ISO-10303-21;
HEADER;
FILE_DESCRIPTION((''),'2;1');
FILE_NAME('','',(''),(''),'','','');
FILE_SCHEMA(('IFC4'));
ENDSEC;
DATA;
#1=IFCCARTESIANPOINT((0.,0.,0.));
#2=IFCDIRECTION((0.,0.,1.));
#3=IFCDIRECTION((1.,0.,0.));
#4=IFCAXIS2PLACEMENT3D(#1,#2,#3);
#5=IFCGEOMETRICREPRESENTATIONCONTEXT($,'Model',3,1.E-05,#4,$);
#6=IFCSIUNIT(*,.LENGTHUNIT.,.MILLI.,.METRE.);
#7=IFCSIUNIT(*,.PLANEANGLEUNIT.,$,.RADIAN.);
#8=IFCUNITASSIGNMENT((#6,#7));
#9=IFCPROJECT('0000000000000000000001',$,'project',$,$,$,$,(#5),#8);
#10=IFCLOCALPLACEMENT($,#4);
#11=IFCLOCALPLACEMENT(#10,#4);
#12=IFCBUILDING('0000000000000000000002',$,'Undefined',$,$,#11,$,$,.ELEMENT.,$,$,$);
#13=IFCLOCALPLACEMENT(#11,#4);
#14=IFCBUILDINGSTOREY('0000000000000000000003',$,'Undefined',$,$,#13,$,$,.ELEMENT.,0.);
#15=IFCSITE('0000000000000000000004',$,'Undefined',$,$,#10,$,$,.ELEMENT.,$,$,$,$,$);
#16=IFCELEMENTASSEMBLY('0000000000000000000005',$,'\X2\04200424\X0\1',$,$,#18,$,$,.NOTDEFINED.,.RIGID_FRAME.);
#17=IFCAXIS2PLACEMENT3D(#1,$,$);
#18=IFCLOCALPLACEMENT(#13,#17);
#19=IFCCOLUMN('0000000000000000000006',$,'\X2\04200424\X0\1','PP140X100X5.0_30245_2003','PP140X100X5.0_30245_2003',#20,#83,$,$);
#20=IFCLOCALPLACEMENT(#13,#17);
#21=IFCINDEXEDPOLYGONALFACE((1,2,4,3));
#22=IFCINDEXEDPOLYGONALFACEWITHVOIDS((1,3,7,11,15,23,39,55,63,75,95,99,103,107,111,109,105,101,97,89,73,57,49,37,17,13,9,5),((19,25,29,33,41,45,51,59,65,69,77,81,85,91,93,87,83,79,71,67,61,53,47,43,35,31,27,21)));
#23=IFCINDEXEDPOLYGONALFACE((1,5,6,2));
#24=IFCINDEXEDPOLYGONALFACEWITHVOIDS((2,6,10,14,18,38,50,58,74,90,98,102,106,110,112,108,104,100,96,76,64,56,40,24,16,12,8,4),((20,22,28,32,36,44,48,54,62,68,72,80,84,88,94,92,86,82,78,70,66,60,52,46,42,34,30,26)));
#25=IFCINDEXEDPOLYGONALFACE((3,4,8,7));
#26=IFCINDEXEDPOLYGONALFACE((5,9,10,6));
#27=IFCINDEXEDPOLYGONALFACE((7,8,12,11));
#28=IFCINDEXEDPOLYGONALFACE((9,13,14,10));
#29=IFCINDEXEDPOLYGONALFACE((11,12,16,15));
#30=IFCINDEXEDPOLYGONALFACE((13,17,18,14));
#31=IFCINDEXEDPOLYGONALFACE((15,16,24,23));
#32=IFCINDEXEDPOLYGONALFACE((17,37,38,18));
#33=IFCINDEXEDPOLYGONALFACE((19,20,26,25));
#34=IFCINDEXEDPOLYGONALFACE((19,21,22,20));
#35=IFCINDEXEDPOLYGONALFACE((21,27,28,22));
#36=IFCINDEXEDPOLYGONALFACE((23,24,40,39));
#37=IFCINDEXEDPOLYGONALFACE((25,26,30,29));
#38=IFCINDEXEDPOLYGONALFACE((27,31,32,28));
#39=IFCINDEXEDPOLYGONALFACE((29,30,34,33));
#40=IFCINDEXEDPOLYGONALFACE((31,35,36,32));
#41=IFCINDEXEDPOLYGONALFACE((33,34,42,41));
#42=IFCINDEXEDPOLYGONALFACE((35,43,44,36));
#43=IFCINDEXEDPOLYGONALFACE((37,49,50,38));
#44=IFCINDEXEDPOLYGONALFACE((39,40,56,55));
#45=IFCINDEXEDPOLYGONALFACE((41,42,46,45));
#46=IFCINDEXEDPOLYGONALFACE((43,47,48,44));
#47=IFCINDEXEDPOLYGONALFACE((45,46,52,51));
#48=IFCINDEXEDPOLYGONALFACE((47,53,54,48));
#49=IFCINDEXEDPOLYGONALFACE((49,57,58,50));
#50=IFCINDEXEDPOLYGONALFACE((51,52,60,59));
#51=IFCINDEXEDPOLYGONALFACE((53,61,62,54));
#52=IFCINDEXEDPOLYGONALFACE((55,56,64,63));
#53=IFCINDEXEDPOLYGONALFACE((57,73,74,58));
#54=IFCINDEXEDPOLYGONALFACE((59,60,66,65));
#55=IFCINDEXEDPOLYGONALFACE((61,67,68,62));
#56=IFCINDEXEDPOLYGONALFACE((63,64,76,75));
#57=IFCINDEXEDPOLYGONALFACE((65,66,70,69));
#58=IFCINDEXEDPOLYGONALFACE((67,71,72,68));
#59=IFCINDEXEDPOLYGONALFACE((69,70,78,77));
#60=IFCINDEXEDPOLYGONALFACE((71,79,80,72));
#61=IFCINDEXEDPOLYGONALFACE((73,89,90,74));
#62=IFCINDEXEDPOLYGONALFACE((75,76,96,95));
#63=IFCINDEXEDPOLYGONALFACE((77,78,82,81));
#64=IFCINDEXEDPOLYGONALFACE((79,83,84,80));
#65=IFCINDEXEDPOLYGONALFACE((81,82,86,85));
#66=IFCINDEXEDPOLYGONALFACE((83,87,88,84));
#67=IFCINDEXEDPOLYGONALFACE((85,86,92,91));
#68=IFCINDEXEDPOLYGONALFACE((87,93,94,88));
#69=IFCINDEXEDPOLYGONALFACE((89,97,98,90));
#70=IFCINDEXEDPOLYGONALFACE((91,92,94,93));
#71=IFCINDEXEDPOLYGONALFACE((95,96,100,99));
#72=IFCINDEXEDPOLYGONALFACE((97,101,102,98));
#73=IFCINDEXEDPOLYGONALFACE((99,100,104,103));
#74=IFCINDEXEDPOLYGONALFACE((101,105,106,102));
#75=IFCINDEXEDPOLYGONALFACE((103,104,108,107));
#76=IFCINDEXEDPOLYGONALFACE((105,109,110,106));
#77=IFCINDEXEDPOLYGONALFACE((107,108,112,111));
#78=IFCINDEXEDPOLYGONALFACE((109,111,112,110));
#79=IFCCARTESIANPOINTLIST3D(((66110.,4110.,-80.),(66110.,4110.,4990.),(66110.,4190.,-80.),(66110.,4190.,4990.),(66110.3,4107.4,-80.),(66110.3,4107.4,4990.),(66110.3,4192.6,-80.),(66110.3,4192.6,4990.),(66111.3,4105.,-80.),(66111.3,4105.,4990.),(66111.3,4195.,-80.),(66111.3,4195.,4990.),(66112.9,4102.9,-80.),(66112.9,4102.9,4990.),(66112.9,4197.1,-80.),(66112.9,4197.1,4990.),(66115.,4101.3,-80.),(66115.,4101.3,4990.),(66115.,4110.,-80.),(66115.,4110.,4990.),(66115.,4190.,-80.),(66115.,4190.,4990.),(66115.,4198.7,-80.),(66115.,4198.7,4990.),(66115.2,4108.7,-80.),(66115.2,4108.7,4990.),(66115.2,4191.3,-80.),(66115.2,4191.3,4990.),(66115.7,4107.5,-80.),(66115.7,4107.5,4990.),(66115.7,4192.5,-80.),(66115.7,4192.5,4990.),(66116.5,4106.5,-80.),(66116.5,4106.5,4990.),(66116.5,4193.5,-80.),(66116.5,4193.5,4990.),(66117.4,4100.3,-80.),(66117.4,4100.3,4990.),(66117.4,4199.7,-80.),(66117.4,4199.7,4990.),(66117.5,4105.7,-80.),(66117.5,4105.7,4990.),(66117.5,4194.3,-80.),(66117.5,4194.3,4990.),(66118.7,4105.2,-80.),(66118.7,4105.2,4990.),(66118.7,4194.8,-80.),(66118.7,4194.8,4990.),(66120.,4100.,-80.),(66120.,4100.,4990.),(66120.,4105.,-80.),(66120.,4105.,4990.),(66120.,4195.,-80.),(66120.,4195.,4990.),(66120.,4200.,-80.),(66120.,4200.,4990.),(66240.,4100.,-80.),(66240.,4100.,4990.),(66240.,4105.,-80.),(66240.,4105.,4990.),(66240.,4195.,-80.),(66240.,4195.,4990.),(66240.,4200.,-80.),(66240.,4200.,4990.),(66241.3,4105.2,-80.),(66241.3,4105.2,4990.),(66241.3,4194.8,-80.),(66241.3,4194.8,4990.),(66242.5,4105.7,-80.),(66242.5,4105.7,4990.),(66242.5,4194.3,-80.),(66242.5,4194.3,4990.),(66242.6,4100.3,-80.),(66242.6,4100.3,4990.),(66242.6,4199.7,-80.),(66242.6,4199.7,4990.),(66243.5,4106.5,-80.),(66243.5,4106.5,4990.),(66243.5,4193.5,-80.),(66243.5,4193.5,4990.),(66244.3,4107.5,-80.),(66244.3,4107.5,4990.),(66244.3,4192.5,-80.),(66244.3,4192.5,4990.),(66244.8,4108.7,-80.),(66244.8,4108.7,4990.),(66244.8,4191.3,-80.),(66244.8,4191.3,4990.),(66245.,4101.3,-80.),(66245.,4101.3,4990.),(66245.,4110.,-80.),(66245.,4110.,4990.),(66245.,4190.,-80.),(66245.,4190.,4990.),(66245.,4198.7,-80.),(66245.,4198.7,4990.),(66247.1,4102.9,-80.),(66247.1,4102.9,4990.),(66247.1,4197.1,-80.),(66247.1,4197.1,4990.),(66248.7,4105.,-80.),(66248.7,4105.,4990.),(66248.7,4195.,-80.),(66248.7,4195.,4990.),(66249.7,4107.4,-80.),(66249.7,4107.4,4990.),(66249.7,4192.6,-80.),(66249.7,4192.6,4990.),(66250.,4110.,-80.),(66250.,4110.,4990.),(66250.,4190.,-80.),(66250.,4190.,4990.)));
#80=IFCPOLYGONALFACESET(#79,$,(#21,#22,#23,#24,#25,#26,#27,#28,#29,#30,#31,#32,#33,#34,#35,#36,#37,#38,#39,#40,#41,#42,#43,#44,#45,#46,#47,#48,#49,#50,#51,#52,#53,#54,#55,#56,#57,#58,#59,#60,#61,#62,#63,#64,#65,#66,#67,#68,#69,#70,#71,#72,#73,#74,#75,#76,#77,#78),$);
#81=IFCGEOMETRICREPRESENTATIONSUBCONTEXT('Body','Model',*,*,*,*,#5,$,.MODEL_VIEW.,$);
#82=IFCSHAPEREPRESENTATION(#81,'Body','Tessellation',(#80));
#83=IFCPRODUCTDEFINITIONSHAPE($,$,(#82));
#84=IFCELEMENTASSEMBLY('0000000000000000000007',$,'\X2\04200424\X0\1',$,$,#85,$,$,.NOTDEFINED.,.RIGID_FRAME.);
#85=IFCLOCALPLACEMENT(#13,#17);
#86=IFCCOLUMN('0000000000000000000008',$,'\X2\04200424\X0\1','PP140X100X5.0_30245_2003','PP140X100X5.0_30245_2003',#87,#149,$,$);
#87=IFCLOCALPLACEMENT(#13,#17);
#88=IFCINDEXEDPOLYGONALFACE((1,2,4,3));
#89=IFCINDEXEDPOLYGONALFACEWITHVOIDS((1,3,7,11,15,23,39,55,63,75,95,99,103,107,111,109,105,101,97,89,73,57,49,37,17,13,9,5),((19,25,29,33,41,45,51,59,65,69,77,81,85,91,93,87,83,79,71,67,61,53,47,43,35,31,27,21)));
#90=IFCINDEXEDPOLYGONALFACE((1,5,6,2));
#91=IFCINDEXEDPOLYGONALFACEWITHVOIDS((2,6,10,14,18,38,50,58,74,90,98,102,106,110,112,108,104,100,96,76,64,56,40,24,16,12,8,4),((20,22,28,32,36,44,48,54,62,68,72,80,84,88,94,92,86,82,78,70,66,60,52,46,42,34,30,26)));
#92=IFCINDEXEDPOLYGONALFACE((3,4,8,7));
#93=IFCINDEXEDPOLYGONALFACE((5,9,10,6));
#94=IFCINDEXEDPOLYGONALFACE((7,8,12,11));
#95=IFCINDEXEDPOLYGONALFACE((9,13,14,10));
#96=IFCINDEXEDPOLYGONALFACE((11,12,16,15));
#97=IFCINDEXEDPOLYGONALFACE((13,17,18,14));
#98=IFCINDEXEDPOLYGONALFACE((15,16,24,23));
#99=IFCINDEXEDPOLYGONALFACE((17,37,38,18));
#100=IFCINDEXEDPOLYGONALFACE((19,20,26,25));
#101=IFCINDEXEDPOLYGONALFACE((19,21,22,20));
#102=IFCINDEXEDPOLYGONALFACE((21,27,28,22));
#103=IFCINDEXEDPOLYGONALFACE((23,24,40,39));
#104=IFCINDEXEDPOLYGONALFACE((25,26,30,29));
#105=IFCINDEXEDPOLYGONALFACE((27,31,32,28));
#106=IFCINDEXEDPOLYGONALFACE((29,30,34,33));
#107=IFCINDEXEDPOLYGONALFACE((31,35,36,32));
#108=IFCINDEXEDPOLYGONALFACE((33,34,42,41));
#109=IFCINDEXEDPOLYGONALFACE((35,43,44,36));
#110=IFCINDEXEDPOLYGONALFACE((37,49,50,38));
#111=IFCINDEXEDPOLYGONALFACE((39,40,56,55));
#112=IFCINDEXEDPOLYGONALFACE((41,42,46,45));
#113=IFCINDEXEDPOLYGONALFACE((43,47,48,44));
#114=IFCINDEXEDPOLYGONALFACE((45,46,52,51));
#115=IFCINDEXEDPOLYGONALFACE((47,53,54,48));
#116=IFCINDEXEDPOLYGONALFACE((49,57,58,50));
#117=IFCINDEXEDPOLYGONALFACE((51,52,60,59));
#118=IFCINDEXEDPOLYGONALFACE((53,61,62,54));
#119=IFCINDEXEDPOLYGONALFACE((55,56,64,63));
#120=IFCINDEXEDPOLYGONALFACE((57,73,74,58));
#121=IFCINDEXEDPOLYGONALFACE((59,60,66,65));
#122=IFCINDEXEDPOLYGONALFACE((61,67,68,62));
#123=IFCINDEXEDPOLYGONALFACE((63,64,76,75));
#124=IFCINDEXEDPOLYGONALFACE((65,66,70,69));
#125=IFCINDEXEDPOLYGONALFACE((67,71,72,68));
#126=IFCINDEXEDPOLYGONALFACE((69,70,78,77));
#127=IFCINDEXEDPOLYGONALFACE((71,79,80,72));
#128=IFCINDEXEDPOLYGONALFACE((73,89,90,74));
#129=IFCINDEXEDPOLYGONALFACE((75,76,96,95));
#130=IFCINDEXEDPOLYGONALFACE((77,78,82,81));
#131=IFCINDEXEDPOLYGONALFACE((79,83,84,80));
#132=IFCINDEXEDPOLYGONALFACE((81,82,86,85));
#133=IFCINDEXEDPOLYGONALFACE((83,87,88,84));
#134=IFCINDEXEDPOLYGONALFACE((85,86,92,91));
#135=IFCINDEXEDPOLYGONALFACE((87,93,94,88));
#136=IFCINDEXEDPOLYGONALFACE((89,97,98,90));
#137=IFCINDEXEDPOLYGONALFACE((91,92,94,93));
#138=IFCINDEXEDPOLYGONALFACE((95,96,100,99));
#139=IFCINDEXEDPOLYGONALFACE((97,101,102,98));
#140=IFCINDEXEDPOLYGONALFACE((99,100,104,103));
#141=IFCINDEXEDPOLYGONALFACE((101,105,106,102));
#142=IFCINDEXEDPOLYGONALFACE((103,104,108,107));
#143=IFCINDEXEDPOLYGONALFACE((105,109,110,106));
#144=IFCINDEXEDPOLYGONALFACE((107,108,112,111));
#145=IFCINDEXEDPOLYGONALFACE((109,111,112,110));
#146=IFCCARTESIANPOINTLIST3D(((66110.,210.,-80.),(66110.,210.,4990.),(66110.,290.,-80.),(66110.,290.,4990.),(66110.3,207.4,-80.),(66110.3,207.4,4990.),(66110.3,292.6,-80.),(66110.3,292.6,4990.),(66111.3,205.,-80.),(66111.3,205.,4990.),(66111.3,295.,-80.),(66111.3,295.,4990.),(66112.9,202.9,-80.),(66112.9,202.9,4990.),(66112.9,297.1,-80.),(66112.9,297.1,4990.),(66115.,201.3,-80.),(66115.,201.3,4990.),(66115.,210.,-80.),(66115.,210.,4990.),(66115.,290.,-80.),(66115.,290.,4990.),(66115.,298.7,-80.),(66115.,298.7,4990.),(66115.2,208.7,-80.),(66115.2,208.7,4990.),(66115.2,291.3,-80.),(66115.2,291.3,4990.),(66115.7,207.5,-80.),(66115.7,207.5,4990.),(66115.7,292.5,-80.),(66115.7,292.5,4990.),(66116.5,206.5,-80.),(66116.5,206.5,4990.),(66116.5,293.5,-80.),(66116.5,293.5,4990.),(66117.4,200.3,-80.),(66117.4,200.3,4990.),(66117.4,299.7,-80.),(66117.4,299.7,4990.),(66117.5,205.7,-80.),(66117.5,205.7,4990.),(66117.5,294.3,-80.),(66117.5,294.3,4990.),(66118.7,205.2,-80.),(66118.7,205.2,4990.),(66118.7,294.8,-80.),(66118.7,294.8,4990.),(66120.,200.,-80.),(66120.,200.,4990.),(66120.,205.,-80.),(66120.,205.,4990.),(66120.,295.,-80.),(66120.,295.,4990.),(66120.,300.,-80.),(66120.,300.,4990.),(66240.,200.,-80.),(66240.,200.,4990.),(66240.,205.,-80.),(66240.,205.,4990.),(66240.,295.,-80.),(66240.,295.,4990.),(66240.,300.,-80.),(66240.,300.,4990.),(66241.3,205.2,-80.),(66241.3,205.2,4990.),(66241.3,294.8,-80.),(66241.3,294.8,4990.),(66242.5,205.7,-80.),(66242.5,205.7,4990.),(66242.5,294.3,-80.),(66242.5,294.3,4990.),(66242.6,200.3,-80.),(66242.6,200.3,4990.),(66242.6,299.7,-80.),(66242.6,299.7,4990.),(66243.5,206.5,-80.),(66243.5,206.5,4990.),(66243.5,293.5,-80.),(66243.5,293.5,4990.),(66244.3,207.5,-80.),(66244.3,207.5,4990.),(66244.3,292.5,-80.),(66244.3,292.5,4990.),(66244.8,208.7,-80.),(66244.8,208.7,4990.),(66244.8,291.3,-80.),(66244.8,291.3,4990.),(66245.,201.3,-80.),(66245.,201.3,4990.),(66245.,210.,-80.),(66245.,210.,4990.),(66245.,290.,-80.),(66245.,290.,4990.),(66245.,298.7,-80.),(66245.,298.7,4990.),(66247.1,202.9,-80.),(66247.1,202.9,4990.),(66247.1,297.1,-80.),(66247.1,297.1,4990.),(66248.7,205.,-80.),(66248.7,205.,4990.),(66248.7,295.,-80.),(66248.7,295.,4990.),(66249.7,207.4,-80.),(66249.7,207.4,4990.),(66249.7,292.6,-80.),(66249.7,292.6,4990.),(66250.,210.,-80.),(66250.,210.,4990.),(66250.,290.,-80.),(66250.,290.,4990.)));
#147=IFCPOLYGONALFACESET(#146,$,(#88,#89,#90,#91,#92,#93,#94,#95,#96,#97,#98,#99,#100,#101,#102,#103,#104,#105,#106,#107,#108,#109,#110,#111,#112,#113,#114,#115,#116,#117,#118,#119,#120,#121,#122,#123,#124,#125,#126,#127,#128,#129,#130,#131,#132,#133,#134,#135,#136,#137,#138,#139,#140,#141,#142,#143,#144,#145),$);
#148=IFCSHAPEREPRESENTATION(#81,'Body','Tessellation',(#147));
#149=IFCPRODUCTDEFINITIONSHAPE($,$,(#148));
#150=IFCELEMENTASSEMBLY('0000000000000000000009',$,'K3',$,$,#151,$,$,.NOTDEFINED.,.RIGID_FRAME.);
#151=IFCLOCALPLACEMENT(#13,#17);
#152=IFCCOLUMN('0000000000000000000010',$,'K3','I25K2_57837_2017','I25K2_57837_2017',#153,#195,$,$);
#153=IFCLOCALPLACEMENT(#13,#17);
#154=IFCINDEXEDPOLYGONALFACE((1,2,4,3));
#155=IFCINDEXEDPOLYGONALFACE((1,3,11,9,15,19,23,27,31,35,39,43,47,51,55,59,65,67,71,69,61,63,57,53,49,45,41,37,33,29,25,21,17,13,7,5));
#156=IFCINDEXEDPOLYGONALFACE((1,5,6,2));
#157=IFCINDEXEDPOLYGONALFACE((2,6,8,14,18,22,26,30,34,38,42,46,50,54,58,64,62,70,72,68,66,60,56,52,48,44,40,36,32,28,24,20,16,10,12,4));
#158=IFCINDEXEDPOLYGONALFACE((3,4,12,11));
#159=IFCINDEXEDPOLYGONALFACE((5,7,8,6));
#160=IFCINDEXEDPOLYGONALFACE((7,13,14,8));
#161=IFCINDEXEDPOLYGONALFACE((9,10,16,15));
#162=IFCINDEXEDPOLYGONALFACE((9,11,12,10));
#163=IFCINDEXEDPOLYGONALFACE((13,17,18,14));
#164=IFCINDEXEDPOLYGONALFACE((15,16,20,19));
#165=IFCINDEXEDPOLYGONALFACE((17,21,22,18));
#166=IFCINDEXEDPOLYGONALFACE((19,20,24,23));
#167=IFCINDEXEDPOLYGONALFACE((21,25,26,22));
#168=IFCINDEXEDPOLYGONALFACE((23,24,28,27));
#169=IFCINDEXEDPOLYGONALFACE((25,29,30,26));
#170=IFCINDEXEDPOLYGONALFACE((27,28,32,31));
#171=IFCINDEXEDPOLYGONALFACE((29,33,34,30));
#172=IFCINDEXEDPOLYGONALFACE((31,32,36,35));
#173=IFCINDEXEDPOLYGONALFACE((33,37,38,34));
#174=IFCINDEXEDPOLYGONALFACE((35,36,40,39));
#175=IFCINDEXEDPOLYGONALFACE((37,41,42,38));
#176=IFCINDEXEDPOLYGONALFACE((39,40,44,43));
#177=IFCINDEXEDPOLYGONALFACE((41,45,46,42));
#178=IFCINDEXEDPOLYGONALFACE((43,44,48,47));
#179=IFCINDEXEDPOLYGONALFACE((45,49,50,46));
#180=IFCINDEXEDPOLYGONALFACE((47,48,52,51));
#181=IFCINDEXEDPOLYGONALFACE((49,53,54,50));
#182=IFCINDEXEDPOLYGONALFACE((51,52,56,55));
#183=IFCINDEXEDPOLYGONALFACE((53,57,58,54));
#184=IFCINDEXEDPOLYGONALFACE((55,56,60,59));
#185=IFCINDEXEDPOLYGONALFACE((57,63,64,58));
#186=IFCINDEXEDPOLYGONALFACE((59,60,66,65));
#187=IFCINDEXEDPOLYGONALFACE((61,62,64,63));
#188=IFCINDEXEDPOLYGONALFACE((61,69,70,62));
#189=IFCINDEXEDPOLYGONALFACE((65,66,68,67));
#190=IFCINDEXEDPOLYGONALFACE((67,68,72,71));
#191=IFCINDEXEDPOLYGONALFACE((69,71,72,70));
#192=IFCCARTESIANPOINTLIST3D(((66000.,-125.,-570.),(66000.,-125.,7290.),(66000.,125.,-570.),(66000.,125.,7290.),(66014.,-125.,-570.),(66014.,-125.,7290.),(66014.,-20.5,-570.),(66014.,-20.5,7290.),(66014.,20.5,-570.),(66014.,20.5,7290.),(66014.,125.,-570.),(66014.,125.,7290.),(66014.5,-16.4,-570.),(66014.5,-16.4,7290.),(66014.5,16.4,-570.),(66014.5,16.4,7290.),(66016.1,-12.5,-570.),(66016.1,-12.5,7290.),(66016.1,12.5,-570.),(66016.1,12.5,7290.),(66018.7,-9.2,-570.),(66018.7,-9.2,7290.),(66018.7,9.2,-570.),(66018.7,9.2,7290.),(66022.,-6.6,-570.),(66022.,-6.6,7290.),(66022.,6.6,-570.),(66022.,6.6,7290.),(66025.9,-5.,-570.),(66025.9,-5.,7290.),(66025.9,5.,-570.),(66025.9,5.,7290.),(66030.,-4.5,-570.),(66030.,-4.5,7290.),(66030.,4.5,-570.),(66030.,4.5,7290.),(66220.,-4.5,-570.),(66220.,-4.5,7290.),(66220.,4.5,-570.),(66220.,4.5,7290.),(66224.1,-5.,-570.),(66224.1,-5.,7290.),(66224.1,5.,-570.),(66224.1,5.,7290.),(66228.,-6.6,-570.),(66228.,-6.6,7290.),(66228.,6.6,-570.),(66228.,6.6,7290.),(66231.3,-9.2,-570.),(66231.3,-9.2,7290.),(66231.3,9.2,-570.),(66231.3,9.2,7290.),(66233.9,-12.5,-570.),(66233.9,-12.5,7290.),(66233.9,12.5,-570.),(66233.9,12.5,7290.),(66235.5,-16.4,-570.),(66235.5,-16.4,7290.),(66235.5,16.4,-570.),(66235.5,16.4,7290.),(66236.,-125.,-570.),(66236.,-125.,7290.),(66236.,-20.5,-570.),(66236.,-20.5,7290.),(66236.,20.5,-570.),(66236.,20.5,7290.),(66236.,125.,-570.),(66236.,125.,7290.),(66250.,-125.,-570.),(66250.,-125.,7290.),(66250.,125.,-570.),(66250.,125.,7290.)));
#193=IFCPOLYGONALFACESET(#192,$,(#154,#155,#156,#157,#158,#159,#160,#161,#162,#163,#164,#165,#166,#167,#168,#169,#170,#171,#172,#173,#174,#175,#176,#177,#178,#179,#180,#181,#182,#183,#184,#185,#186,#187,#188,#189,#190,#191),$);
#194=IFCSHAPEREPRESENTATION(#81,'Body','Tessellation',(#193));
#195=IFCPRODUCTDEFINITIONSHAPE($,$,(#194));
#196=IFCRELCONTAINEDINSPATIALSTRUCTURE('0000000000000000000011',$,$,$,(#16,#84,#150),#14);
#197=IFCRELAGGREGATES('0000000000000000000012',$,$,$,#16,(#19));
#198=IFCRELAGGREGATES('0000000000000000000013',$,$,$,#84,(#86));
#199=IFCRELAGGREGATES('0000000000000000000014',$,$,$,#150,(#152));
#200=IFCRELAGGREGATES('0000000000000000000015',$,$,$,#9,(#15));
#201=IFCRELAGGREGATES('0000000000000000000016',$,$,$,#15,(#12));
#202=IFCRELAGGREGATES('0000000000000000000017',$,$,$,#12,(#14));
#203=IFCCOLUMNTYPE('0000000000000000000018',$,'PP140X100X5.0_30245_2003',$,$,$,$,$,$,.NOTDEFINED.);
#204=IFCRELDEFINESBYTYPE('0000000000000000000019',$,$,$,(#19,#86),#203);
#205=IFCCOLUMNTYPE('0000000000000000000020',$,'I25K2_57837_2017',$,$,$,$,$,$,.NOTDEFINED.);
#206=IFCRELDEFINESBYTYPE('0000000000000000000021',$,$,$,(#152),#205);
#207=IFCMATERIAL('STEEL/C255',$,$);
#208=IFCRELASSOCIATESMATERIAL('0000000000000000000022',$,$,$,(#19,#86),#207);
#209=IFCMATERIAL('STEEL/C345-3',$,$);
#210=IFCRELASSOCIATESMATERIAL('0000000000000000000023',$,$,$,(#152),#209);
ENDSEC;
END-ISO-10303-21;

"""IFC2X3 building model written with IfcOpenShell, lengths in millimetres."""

from ifc_helpers import new_model, si_unit, frame, origin_with_axes, origin_2d_with_axis, place, context, subcontext, project, spatial, hollow_rectangle, i_section, extrude, material, type_object, element, aggregate, save


model = new_model("IFC2X3")

# Units and contexts
model_context = context("Model", 3, precision=1e-05, world=origin_with_axes())
body_context = subcontext(model_context, "Body", "Model", "MODEL_VIEW")
ifc_project = project(units=[si_unit("LENGTHUNIT", "METRE", prefix="MILLI"), si_unit("PLANEANGLEUNIT", "RADIAN")], contexts=[model_context])

# Site, building, storey
site_placement = place(None, origin_with_axes())
site = spatial("IfcSite", under=ifc_project, at=site_placement, Name="Undefined", CompositionType="ELEMENT")
building_placement = place(site_placement, origin_with_axes())
building = spatial("IfcBuilding", under=site, at=building_placement, Name="Undefined", CompositionType="ELEMENT")
storey_placement = place(building_placement, origin_with_axes())
storey = spatial("IfcBuildingStorey", under=building, at=storey_placement, Name="Undefined", CompositionType="ELEMENT", Elevation=0.0)

# Element assemblies, columns
assembly_1_placement = place(storey_placement, origin_with_axes())
assembly_1 = element("IfcElementAssembly", 1, at=assembly_1_placement, inside=storey, Name="РФ1", AssemblyPlace="NOTDEFINED", PredefinedType="RIGID_FRAME")
ifc_material_1 = material(Name="STEEL/C255")
column_type_1 = type_object("IfcColumnType", Name="PP140X100X5.0_30245_2003", PredefinedType="NOTDEFINED")
column_1_placement = place(assembly_1_placement, frame((66180.0, 4150.0, -80.0), z_axis=(0.0, 0.0, 1.0), x_axis=(-1.0, 0.0, 0.0)))
column_1 = element("IfcColumn", 2, at=column_1_placement, type_object=column_type_1, material=ifc_material_1, Name="РФ1", Description="PP140X100X5.0_30245_2003", ObjectType="PP140X100X5.0_30245_2003", context=body_context, shape_type="SweptSolid", body=[
    extrude(hollow_rectangle(XDim=100.0, YDim=140.0, WallThickness=5.0, InnerFilletRadius=5.0, OuterFilletRadius=10.0, at=origin_2d_with_axis()), frame((0.0, 0.0, 5070.0), z_axis=(0.0, 0.0, -1.0), x_axis=(0.0, 1.0, 0.0)), (0.0, 0.0, 1.0), 5070.0),
])
aggregate(assembly_1, [column_1])
assembly_2_placement = place(storey_placement, origin_with_axes())
assembly_2 = element("IfcElementAssembly", 3, at=assembly_2_placement, inside=storey, Name="РФ1", AssemblyPlace="NOTDEFINED", PredefinedType="RIGID_FRAME")
column_2_placement = place(assembly_2_placement, frame((66180.0, 250.0, -80.0), z_axis=(0.0, 0.0, 1.0), x_axis=(1.0, 0.0, 0.0)))
column_2 = element("IfcColumn", 4, at=column_2_placement, type_object=column_type_1, material=ifc_material_1, Name="РФ1", Description="PP140X100X5.0_30245_2003", ObjectType="PP140X100X5.0_30245_2003", context=body_context, shape_type="SweptSolid", body=[
    extrude(hollow_rectangle(XDim=100.0, YDim=140.0, WallThickness=5.0, InnerFilletRadius=5.0, OuterFilletRadius=10.0, at=origin_2d_with_axis()), frame((0.0, 0.0, 5070.0), z_axis=(0.0, 0.0, -1.0), x_axis=(0.0, 1.0, 0.0)), (0.0, 0.0, 1.0), 5070.0),
])
aggregate(assembly_2, [column_2])
assembly_3_placement = place(storey_placement, origin_with_axes())
assembly_3 = element("IfcElementAssembly", 5, at=assembly_3_placement, inside=storey, Name="K3", AssemblyPlace="NOTDEFINED", PredefinedType="RIGID_FRAME")
ifc_material_2 = material(Name="STEEL/C345-3")
column_type_2 = type_object("IfcColumnType", Name="I25K2_57837_2017", PredefinedType="NOTDEFINED")
column_3_placement = place(assembly_3_placement, frame((66125.0, 0.0, -570.0), z_axis=(0.0, 0.0, 1.0), x_axis=(1.0, 0.0, 0.0)))
column_3 = element("IfcColumn", 6, at=column_3_placement, type_object=column_type_2, material=ifc_material_2, Name="K3", Description="I25K2_57837_2017", ObjectType="I25K2_57837_2017", context=body_context, shape_type="SweptSolid", body=[
    extrude(i_section(OverallWidth=250.0, OverallDepth=250.0, WebThickness=9.0, FlangeThickness=14.0, FilletRadius=16.0, at=origin_2d_with_axis()), frame((0.0, 0.0, 7860.0), z_axis=(0.0, 0.0, -1.0), x_axis=(0.0, 1.0, 0.0)), (0.0, 0.0, 1.0), 7860.0),
])
aggregate(assembly_3, [column_3])

save(model, "model.ifc")
